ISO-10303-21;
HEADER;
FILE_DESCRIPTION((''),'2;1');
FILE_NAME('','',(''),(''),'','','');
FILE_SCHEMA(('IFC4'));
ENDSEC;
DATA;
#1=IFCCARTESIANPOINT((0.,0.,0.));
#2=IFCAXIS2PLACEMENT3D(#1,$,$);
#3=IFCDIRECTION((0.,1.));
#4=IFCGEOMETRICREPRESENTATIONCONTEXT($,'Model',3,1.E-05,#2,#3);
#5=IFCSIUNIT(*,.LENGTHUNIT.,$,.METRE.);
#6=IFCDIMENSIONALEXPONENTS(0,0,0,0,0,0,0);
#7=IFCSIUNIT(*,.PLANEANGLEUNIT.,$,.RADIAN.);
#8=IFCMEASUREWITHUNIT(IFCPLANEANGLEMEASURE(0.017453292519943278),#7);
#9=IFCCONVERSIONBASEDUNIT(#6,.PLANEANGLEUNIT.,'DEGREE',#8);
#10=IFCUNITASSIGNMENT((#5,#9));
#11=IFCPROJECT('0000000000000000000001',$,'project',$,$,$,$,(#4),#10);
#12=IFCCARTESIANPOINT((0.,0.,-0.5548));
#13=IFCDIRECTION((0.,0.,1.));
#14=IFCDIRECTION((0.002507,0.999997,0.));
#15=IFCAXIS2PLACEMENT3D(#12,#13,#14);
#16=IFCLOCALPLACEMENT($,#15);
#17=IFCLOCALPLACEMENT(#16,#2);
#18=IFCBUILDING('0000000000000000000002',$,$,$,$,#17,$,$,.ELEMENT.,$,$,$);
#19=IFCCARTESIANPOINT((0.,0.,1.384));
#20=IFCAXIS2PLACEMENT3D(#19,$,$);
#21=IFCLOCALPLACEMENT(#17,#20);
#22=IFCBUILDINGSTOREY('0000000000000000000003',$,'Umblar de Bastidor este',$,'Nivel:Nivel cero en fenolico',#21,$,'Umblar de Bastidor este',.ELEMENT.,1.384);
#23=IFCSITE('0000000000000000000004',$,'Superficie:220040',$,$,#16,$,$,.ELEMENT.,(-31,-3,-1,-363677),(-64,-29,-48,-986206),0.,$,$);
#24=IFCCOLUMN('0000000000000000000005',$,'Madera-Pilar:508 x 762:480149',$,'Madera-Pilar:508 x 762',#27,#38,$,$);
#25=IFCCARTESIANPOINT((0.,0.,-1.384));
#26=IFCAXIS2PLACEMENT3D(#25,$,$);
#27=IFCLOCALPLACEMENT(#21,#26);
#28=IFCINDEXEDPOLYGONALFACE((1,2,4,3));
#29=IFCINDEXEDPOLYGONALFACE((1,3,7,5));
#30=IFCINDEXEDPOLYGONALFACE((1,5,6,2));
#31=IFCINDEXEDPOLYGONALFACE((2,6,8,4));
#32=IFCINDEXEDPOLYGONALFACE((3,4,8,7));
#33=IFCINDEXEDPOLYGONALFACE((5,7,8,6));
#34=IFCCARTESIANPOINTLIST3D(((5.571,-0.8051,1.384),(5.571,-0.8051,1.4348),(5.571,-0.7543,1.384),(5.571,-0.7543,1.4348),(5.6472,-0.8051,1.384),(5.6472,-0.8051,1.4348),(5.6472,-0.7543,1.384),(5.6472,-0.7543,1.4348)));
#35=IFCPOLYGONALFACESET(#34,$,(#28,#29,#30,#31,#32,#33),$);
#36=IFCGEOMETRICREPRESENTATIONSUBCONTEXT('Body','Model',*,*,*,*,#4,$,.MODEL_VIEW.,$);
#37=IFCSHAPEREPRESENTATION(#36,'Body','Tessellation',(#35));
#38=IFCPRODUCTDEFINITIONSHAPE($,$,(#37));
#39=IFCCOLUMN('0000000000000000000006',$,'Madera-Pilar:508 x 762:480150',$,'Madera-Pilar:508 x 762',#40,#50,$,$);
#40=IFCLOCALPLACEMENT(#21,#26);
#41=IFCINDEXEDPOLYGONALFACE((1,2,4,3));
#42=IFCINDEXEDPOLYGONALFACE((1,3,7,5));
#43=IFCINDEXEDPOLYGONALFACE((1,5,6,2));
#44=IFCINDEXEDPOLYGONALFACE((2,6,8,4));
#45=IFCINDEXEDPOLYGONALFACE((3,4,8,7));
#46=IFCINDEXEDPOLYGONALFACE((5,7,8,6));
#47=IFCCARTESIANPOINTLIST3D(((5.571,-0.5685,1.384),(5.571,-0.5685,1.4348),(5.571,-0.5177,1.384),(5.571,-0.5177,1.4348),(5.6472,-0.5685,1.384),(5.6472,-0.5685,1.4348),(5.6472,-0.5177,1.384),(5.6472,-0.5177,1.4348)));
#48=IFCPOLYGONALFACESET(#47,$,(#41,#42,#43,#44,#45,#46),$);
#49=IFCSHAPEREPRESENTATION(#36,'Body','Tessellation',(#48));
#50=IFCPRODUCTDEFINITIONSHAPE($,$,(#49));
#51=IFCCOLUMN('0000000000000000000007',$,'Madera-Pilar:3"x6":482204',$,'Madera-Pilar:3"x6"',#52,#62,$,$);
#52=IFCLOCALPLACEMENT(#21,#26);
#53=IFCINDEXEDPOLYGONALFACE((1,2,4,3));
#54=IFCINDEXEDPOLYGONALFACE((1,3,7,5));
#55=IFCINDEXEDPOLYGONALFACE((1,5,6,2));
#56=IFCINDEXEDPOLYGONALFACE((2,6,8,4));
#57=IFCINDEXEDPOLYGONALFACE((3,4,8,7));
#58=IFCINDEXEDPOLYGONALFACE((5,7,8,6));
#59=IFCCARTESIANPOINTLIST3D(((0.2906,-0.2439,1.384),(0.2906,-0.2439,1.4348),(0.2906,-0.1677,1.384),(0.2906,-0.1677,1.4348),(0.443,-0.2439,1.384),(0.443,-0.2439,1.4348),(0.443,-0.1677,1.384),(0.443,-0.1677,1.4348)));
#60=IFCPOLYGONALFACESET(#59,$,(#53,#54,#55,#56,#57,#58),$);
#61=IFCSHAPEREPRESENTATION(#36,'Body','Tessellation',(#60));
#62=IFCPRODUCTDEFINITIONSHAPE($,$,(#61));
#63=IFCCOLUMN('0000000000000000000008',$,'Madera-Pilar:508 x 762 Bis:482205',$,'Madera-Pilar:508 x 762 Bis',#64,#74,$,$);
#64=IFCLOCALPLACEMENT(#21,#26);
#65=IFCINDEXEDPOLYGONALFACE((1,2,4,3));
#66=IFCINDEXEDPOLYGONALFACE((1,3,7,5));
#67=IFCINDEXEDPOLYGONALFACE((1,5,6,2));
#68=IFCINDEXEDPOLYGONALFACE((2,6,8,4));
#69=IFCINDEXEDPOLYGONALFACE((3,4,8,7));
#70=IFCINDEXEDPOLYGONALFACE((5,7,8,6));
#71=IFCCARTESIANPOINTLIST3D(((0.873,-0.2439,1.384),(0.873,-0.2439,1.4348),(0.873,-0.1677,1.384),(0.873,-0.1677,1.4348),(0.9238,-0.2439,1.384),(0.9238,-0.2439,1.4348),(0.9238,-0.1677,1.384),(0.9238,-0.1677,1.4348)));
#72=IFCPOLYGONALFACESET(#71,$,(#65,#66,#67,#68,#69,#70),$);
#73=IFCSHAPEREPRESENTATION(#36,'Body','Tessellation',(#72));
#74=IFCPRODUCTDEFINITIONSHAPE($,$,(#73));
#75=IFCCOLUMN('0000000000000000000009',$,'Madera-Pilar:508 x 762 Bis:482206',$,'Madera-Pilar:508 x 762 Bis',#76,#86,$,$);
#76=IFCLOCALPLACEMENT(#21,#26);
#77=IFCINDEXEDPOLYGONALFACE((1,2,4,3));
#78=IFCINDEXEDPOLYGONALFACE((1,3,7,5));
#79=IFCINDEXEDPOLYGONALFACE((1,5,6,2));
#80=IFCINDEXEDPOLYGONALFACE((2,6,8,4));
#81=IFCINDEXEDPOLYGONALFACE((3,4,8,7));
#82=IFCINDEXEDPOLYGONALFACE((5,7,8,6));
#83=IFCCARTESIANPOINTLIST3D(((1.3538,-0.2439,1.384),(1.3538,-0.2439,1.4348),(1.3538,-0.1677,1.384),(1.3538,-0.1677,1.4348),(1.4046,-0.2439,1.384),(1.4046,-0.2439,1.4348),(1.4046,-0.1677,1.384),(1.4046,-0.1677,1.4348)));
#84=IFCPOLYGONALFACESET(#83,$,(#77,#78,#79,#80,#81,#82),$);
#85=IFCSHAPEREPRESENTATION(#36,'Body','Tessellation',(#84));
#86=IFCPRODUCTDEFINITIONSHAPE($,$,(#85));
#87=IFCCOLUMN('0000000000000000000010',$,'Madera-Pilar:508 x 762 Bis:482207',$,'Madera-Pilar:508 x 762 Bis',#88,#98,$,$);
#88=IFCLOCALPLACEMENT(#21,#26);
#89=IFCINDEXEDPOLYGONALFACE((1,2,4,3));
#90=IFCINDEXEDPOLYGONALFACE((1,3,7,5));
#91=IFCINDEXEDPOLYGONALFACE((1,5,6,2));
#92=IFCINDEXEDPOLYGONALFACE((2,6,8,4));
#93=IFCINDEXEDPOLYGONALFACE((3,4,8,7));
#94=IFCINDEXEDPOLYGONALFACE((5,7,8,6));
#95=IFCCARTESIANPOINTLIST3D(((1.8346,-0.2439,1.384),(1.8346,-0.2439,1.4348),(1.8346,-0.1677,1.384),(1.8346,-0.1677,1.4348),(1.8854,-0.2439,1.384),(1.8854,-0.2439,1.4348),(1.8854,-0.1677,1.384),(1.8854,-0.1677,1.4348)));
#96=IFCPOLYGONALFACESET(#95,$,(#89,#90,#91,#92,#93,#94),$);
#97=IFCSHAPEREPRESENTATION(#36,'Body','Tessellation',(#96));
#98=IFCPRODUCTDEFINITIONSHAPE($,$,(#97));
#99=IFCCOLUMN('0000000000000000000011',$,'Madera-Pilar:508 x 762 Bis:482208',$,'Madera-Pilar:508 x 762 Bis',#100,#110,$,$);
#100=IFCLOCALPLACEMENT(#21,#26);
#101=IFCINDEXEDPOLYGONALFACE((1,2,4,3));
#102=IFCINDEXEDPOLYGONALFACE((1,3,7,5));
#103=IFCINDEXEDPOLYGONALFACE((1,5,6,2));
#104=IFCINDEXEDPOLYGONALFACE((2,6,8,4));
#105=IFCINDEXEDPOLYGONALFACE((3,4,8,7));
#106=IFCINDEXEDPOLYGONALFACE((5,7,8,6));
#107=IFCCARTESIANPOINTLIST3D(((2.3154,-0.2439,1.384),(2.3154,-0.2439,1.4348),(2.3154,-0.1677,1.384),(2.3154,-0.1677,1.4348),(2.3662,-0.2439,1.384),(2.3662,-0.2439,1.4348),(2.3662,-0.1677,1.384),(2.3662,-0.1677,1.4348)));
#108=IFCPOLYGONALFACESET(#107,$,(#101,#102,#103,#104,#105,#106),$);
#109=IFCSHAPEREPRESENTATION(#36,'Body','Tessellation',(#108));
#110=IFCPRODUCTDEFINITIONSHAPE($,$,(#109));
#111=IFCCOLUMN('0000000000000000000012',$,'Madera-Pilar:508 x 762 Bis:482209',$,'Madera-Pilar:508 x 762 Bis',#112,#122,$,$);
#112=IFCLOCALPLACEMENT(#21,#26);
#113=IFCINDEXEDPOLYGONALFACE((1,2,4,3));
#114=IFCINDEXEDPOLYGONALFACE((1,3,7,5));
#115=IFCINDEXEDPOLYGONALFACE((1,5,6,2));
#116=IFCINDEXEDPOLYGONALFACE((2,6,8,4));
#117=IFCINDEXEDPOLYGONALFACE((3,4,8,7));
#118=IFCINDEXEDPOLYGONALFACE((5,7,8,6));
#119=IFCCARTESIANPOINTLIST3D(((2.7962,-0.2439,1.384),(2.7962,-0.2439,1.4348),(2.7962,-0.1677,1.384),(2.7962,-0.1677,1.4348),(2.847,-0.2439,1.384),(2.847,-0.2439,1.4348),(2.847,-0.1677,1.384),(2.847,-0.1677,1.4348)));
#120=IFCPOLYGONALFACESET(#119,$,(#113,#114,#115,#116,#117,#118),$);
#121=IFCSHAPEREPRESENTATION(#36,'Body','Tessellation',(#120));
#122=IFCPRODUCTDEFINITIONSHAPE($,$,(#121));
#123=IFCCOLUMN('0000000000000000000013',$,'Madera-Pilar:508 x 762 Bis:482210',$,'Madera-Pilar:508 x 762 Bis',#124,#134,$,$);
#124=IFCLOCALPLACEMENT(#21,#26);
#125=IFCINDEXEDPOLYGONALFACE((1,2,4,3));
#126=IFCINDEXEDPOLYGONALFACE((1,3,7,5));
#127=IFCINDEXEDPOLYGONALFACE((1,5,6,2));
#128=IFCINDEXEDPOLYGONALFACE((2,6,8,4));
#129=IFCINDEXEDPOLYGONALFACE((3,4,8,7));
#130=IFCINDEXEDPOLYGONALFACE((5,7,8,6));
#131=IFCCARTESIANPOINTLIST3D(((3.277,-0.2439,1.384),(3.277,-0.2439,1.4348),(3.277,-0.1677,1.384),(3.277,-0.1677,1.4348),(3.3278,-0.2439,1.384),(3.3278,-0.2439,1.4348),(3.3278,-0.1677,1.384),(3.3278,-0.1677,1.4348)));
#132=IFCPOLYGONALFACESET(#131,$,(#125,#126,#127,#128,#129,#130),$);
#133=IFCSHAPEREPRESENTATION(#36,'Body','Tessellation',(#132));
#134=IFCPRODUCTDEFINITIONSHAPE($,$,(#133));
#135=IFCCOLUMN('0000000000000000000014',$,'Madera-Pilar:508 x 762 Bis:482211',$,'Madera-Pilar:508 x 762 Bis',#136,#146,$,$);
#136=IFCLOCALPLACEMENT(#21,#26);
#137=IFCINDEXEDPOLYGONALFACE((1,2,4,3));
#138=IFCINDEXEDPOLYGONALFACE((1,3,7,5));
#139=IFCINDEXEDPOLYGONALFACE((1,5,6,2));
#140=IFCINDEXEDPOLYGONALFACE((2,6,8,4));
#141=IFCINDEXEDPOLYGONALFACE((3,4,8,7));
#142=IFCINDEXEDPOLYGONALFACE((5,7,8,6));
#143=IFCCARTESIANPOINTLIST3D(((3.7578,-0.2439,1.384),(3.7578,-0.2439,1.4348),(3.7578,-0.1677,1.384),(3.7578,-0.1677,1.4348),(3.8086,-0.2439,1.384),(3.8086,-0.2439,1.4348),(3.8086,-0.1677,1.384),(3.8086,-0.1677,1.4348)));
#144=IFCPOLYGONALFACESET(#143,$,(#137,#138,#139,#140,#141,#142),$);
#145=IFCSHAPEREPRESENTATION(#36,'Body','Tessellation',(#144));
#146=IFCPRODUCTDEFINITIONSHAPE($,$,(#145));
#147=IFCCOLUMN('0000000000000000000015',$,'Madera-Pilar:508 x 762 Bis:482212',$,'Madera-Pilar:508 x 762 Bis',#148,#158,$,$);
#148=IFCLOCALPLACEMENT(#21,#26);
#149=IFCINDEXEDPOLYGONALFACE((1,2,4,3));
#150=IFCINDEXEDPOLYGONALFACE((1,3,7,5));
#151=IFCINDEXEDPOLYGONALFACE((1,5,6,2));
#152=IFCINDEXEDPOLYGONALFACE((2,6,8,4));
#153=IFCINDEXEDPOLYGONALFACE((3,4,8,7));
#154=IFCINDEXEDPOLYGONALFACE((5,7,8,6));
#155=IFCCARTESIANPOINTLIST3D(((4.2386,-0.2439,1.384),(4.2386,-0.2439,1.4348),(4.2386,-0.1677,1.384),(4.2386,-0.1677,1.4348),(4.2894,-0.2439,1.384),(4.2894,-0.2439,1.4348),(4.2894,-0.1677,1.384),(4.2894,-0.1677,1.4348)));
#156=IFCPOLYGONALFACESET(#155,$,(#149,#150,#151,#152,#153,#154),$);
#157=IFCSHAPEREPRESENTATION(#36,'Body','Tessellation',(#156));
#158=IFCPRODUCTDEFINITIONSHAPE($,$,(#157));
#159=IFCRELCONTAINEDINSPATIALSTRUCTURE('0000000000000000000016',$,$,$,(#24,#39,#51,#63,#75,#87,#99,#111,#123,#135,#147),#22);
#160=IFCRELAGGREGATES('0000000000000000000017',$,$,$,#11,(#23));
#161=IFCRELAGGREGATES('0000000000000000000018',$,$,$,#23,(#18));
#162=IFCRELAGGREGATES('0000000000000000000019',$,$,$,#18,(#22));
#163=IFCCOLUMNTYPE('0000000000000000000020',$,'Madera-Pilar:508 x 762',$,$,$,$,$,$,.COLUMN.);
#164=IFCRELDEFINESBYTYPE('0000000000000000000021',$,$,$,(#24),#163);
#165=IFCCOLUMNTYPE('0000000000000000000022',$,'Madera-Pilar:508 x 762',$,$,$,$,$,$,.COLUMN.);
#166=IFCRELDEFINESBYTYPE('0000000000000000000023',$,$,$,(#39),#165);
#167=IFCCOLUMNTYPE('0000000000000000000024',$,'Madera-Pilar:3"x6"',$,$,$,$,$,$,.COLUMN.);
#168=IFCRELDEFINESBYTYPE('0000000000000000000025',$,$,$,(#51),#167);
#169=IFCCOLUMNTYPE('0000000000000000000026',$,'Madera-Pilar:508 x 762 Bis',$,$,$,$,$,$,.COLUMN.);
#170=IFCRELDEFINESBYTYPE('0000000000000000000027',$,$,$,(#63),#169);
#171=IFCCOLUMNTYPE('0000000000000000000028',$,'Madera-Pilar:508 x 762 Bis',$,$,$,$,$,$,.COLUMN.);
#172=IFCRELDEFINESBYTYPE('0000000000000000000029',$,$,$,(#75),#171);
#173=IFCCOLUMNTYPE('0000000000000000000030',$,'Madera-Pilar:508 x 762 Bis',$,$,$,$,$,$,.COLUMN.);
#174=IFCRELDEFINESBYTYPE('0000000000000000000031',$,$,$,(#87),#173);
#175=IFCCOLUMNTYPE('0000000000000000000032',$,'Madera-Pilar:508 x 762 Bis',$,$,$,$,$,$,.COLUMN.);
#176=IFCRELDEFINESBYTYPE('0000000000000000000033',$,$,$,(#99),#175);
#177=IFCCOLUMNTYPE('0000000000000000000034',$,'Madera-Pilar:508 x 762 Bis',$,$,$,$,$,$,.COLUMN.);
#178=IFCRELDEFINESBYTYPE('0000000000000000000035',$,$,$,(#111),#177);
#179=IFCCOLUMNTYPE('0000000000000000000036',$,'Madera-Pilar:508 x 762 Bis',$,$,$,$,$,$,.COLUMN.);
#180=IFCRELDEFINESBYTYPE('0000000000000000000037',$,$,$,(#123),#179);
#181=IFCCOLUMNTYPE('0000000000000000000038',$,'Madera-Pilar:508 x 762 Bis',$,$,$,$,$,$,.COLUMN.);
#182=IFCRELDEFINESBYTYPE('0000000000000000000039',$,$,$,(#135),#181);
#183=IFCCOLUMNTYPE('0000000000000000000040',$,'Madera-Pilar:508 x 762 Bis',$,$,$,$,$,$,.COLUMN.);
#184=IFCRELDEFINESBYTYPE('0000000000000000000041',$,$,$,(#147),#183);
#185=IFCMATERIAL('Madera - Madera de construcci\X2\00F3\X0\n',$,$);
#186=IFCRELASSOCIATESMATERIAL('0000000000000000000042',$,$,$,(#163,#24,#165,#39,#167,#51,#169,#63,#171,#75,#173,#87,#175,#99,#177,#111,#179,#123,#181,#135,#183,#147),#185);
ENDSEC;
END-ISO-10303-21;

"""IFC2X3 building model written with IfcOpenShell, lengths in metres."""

from ifc_helpers import new_model, entity, si_unit, converted_unit, direction, frame, frame_2d, origin, origin_2d_with_axis, place, context, subcontext, project, spatial, rectangle, extrude, source, transform, mapped, material, type_object, type_shapes, element, save


model = new_model("IFC2X3")

# Units and contexts
model_context = context("Model", 3, precision=1e-05, world=origin(), true_north=direction((0.0, 1.0)))
body_context = subcontext(model_context, "Body", "Model", "MODEL_VIEW")
ifc_project = project(units=[si_unit("LENGTHUNIT", "METRE"), converted_unit("PLANEANGLEUNIT", "DEGREE", entity("IfcPlaneAngleMeasure", 0.017453292519943278), si_unit("PLANEANGLEUNIT", "RADIAN"), dimensions=[0, 0, 0, 0, 0, 0, 0])], contexts=[model_context])

# Site, building, storey
site_placement = place(None, frame((0.0, 0.0, -0.5548), z_axis=(0.0, 0.0, 1.0), x_axis=(0.002507, 0.999997, 0.0)))
site = spatial("IfcSite", under=ifc_project, at=site_placement, Name="Superficie:220040", CompositionType="ELEMENT", RefLatitude=(-31, -3, -1, -363677), RefLongitude=(-64, -29, -48, -986206), RefElevation=0.0)
building_placement = place(site_placement, origin())
building = spatial("IfcBuilding", under=site, at=building_placement, CompositionType="ELEMENT")
storey_placement = place(building_placement, frame((0.0, 0.0, 1.384)))
storey = spatial("IfcBuildingStorey", under=building, at=storey_placement, Name="Umblar de Bastidor este", ObjectType="Nivel:Nivel cero en fenolico", LongName="Umblar de Bastidor este", CompositionType="ELEMENT", Elevation=1.384)

# Columns
ifc_material = material(Name="Madera - Madera de construcción")
column_type_1 = type_object("IfcColumnType", Name="Madera-Pilar:508 x 762", PredefinedType="COLUMN", material=ifc_material)
shared_shape_1 = source(origin(), body_context, "Body", "SweptSolid", [
    extrude(rectangle(XDim=0.0762, YDim=0.0508, at=frame_2d((0.0, 0.0), x_axis=(1.0, 0.0))), frame((5.6091, -0.7797, 1.384), z_axis=(0.0, 0.0, 1.0), x_axis=(-1.0, 0.0, 0.0)), (0.0, 0.0, 1.0), 0.0508),
])
type_shapes(column_type_1, [shared_shape_1])
column_1_placement = place(storey_placement, frame((0.0, 0.0, -1.384)))
element("IfcColumn", 1, at=column_1_placement, inside=storey, type_object=column_type_1, material=ifc_material, Name="Madera-Pilar:508 x 762:480149", ObjectType="Madera-Pilar:508 x 762", context=body_context, shape_type="MappedRepresentation", body=[
    mapped(shared_shape_1, transform((0.0, 0.0, 0.0), scale=1.0)),
])
column_type_2 = type_object("IfcColumnType", Name="Madera-Pilar:508 x 762", PredefinedType="COLUMN", material=ifc_material)
shared_shape_2 = source(origin(), body_context, "Body", "SweptSolid", [
    extrude(rectangle(XDim=0.0762, YDim=0.0508, at=origin_2d_with_axis()), frame((5.6091, -0.5431, 1.384), z_axis=(0.0, 0.0, 1.0), x_axis=(-1.0, 0.0, 0.0)), (0.0, 0.0, 1.0), 0.0508),
])
type_shapes(column_type_2, [shared_shape_2])
column_2_placement = place(storey_placement, frame((0.0, 0.0, -1.384)))
element("IfcColumn", 2, at=column_2_placement, inside=storey, type_object=column_type_2, material=ifc_material, Name="Madera-Pilar:508 x 762:480150", ObjectType="Madera-Pilar:508 x 762", context=body_context, shape_type="MappedRepresentation", body=[
    mapped(shared_shape_2, transform((0.0, 0.0, 0.0), scale=1.0)),
])
column_type_3 = type_object("IfcColumnType", Name="Madera-Pilar:3\"x6\"", PredefinedType="COLUMN", material=ifc_material)
shared_shape_3 = source(origin(), body_context, "Body", "SweptSolid", [
    extrude(rectangle(XDim=0.1524, YDim=0.0762, at=frame_2d((0.0, 0.0), x_axis=(1.0, 0.0))), frame((0.3668, -0.2058, 1.384), z_axis=(0.0, 0.0, 1.0), x_axis=(-1.0, 0.0, 0.0)), (0.0, 0.0, 1.0), 0.0508),
])
type_shapes(column_type_3, [shared_shape_3])
column_3_placement = place(storey_placement, frame((0.0, 0.0, -1.384)))
element("IfcColumn", 3, at=column_3_placement, inside=storey, type_object=column_type_3, material=ifc_material, Name="Madera-Pilar:3\"x6\":482204", ObjectType="Madera-Pilar:3\"x6\"", context=body_context, shape_type="MappedRepresentation", body=[
    mapped(shared_shape_3, transform((0.0, 0.0, 0.0), scale=1.0)),
])
column_type_4 = type_object("IfcColumnType", Name="Madera-Pilar:508 x 762 Bis", PredefinedType="COLUMN", material=ifc_material)
shared_shape_4 = source(origin(), body_context, "Body", "SweptSolid", [
    extrude(rectangle(XDim=0.0508, YDim=0.0762, at=origin_2d_with_axis()), frame((0.8984, -0.2058, 1.384), z_axis=(0.0, 0.0, 1.0), x_axis=(-1.0, 0.0, 0.0)), (0.0, 0.0, 1.0), 0.0508),
])
type_shapes(column_type_4, [shared_shape_4])
column_4_placement = place(storey_placement, frame((0.0, 0.0, -1.384)))
element("IfcColumn", 4, at=column_4_placement, inside=storey, type_object=column_type_4, material=ifc_material, Name="Madera-Pilar:508 x 762 Bis:482205", ObjectType="Madera-Pilar:508 x 762 Bis", context=body_context, shape_type="MappedRepresentation", body=[
    mapped(shared_shape_4, transform((0.0, 0.0, 0.0), scale=1.0)),
])
column_type_5 = type_object("IfcColumnType", Name="Madera-Pilar:508 x 762 Bis", PredefinedType="COLUMN", material=ifc_material)
shared_shape_5 = source(origin(), body_context, "Body", "SweptSolid", [
    extrude(rectangle(XDim=0.0508, YDim=0.0762, at=frame_2d((0.0, 0.0), x_axis=(1.0, 0.0))), frame((1.3792, -0.2058, 1.384), z_axis=(0.0, 0.0, 1.0), x_axis=(-1.0, 0.0, 0.0)), (0.0, 0.0, 1.0), 0.0508),
])
type_shapes(column_type_5, [shared_shape_5])
column_5_placement = place(storey_placement, frame((0.0, 0.0, -1.384)))
element("IfcColumn", 5, at=column_5_placement, inside=storey, type_object=column_type_5, material=ifc_material, Name="Madera-Pilar:508 x 762 Bis:482206", ObjectType="Madera-Pilar:508 x 762 Bis", context=body_context, shape_type="MappedRepresentation", body=[
    mapped(shared_shape_5, transform((0.0, 0.0, 0.0), scale=1.0)),
])
column_type_6 = type_object("IfcColumnType", Name="Madera-Pilar:508 x 762 Bis", PredefinedType="COLUMN", material=ifc_material)
shared_shape_6 = source(origin(), body_context, "Body", "SweptSolid", [
    extrude(rectangle(XDim=0.0508, YDim=0.0762, at=frame_2d((0.0, 0.0), x_axis=(1.0, 0.0))), frame((1.86, -0.2058, 1.384), z_axis=(0.0, 0.0, 1.0), x_axis=(-1.0, 0.0, 0.0)), (0.0, 0.0, 1.0), 0.0508),
])
type_shapes(column_type_6, [shared_shape_6])
column_6_placement = place(storey_placement, frame((0.0, 0.0, -1.384)))
element("IfcColumn", 6, at=column_6_placement, inside=storey, type_object=column_type_6, material=ifc_material, Name="Madera-Pilar:508 x 762 Bis:482207", ObjectType="Madera-Pilar:508 x 762 Bis", context=body_context, shape_type="MappedRepresentation", body=[
    mapped(shared_shape_6, transform((0.0, 0.0, 0.0), scale=1.0)),
])
column_type_7 = type_object("IfcColumnType", Name="Madera-Pilar:508 x 762 Bis", PredefinedType="COLUMN", material=ifc_material)
shared_shape_7 = source(origin(), body_context, "Body", "SweptSolid", [
    extrude(rectangle(XDim=0.0508, YDim=0.0762, at=frame_2d((0.0, 0.0), x_axis=(1.0, 0.0))), frame((2.3408, -0.2058, 1.384), z_axis=(0.0, 0.0, 1.0), x_axis=(-1.0, 0.0, 0.0)), (0.0, 0.0, 1.0), 0.0508),
])
type_shapes(column_type_7, [shared_shape_7])
column_7_placement = place(storey_placement, frame((0.0, 0.0, -1.384)))
element("IfcColumn", 7, at=column_7_placement, inside=storey, type_object=column_type_7, material=ifc_material, Name="Madera-Pilar:508 x 762 Bis:482208", ObjectType="Madera-Pilar:508 x 762 Bis", context=body_context, shape_type="MappedRepresentation", body=[
    mapped(shared_shape_7, transform((0.0, 0.0, 0.0), scale=1.0)),
])
column_type_8 = type_object("IfcColumnType", Name="Madera-Pilar:508 x 762 Bis", PredefinedType="COLUMN", material=ifc_material)
shared_shape_8 = source(origin(), body_context, "Body", "SweptSolid", [
    extrude(rectangle(XDim=0.0508, YDim=0.0762, at=frame_2d((0.0, 0.0), x_axis=(1.0, 0.0))), frame((2.8216, -0.2058, 1.384), z_axis=(0.0, 0.0, 1.0), x_axis=(-1.0, 0.0, 0.0)), (0.0, 0.0, 1.0), 0.0508),
])
type_shapes(column_type_8, [shared_shape_8])
column_8_placement = place(storey_placement, frame((0.0, 0.0, -1.384)))
element("IfcColumn", 8, at=column_8_placement, inside=storey, type_object=column_type_8, material=ifc_material, Name="Madera-Pilar:508 x 762 Bis:482209", ObjectType="Madera-Pilar:508 x 762 Bis", context=body_context, shape_type="MappedRepresentation", body=[
    mapped(shared_shape_8, transform((0.0, 0.0, 0.0), scale=1.0)),
])
column_type_9 = type_object("IfcColumnType", Name="Madera-Pilar:508 x 762 Bis", PredefinedType="COLUMN", material=ifc_material)
shared_shape_9 = source(origin(), body_context, "Body", "SweptSolid", [
    extrude(rectangle(XDim=0.0508, YDim=0.0762, at=frame_2d((0.0, 0.0), x_axis=(1.0, 0.0))), frame((3.3024, -0.2058, 1.384), z_axis=(0.0, 0.0, 1.0), x_axis=(-1.0, 0.0, 0.0)), (0.0, 0.0, 1.0), 0.0508),
])
type_shapes(column_type_9, [shared_shape_9])
column_9_placement = place(storey_placement, frame((0.0, 0.0, -1.384)))
element("IfcColumn", 9, at=column_9_placement, inside=storey, type_object=column_type_9, material=ifc_material, Name="Madera-Pilar:508 x 762 Bis:482210", ObjectType="Madera-Pilar:508 x 762 Bis", context=body_context, shape_type="MappedRepresentation", body=[
    mapped(shared_shape_9, transform((0.0, 0.0, 0.0), scale=1.0)),
])
column_type_10 = type_object("IfcColumnType", Name="Madera-Pilar:508 x 762 Bis", PredefinedType="COLUMN", material=ifc_material)
shared_shape_10 = source(origin(), body_context, "Body", "SweptSolid", [
    extrude(rectangle(XDim=0.0508, YDim=0.0762, at=frame_2d((0.0, 0.0), x_axis=(1.0, 0.0))), frame((3.7832, -0.2058, 1.384), z_axis=(0.0, 0.0, 1.0), x_axis=(-1.0, 0.0, 0.0)), (0.0, 0.0, 1.0), 0.0508),
])
type_shapes(column_type_10, [shared_shape_10])
column_10_placement = place(storey_placement, frame((0.0, 0.0, -1.384)))
element("IfcColumn", 10, at=column_10_placement, inside=storey, type_object=column_type_10, material=ifc_material, Name="Madera-Pilar:508 x 762 Bis:482211", ObjectType="Madera-Pilar:508 x 762 Bis", context=body_context, shape_type="MappedRepresentation", body=[
    mapped(shared_shape_10, transform((0.0, 0.0, 0.0), scale=1.0)),
])
column_type_11 = type_object("IfcColumnType", Name="Madera-Pilar:508 x 762 Bis", PredefinedType="COLUMN", material=ifc_material)
shared_shape_11 = source(origin(), body_context, "Body", "SweptSolid", [
    extrude(rectangle(XDim=0.0508, YDim=0.0762, at=frame_2d((0.0, 0.0), x_axis=(1.0, 0.0))), frame((4.264, -0.2058, 1.384), z_axis=(0.0, 0.0, 1.0), x_axis=(-1.0, 0.0, 0.0)), (0.0, 0.0, 1.0), 0.0508),
])
type_shapes(column_type_11, [shared_shape_11])
column_11_placement = place(storey_placement, frame((0.0, 0.0, -1.384)))
element("IfcColumn", 11, at=column_11_placement, inside=storey, type_object=column_type_11, material=ifc_material, Name="Madera-Pilar:508 x 762 Bis:482212", ObjectType="Madera-Pilar:508 x 762 Bis", context=body_context, shape_type="MappedRepresentation", body=[
    mapped(shared_shape_11, transform((0.0, 0.0, 0.0), scale=1.0)),
])

save(model, "model.ifc")
